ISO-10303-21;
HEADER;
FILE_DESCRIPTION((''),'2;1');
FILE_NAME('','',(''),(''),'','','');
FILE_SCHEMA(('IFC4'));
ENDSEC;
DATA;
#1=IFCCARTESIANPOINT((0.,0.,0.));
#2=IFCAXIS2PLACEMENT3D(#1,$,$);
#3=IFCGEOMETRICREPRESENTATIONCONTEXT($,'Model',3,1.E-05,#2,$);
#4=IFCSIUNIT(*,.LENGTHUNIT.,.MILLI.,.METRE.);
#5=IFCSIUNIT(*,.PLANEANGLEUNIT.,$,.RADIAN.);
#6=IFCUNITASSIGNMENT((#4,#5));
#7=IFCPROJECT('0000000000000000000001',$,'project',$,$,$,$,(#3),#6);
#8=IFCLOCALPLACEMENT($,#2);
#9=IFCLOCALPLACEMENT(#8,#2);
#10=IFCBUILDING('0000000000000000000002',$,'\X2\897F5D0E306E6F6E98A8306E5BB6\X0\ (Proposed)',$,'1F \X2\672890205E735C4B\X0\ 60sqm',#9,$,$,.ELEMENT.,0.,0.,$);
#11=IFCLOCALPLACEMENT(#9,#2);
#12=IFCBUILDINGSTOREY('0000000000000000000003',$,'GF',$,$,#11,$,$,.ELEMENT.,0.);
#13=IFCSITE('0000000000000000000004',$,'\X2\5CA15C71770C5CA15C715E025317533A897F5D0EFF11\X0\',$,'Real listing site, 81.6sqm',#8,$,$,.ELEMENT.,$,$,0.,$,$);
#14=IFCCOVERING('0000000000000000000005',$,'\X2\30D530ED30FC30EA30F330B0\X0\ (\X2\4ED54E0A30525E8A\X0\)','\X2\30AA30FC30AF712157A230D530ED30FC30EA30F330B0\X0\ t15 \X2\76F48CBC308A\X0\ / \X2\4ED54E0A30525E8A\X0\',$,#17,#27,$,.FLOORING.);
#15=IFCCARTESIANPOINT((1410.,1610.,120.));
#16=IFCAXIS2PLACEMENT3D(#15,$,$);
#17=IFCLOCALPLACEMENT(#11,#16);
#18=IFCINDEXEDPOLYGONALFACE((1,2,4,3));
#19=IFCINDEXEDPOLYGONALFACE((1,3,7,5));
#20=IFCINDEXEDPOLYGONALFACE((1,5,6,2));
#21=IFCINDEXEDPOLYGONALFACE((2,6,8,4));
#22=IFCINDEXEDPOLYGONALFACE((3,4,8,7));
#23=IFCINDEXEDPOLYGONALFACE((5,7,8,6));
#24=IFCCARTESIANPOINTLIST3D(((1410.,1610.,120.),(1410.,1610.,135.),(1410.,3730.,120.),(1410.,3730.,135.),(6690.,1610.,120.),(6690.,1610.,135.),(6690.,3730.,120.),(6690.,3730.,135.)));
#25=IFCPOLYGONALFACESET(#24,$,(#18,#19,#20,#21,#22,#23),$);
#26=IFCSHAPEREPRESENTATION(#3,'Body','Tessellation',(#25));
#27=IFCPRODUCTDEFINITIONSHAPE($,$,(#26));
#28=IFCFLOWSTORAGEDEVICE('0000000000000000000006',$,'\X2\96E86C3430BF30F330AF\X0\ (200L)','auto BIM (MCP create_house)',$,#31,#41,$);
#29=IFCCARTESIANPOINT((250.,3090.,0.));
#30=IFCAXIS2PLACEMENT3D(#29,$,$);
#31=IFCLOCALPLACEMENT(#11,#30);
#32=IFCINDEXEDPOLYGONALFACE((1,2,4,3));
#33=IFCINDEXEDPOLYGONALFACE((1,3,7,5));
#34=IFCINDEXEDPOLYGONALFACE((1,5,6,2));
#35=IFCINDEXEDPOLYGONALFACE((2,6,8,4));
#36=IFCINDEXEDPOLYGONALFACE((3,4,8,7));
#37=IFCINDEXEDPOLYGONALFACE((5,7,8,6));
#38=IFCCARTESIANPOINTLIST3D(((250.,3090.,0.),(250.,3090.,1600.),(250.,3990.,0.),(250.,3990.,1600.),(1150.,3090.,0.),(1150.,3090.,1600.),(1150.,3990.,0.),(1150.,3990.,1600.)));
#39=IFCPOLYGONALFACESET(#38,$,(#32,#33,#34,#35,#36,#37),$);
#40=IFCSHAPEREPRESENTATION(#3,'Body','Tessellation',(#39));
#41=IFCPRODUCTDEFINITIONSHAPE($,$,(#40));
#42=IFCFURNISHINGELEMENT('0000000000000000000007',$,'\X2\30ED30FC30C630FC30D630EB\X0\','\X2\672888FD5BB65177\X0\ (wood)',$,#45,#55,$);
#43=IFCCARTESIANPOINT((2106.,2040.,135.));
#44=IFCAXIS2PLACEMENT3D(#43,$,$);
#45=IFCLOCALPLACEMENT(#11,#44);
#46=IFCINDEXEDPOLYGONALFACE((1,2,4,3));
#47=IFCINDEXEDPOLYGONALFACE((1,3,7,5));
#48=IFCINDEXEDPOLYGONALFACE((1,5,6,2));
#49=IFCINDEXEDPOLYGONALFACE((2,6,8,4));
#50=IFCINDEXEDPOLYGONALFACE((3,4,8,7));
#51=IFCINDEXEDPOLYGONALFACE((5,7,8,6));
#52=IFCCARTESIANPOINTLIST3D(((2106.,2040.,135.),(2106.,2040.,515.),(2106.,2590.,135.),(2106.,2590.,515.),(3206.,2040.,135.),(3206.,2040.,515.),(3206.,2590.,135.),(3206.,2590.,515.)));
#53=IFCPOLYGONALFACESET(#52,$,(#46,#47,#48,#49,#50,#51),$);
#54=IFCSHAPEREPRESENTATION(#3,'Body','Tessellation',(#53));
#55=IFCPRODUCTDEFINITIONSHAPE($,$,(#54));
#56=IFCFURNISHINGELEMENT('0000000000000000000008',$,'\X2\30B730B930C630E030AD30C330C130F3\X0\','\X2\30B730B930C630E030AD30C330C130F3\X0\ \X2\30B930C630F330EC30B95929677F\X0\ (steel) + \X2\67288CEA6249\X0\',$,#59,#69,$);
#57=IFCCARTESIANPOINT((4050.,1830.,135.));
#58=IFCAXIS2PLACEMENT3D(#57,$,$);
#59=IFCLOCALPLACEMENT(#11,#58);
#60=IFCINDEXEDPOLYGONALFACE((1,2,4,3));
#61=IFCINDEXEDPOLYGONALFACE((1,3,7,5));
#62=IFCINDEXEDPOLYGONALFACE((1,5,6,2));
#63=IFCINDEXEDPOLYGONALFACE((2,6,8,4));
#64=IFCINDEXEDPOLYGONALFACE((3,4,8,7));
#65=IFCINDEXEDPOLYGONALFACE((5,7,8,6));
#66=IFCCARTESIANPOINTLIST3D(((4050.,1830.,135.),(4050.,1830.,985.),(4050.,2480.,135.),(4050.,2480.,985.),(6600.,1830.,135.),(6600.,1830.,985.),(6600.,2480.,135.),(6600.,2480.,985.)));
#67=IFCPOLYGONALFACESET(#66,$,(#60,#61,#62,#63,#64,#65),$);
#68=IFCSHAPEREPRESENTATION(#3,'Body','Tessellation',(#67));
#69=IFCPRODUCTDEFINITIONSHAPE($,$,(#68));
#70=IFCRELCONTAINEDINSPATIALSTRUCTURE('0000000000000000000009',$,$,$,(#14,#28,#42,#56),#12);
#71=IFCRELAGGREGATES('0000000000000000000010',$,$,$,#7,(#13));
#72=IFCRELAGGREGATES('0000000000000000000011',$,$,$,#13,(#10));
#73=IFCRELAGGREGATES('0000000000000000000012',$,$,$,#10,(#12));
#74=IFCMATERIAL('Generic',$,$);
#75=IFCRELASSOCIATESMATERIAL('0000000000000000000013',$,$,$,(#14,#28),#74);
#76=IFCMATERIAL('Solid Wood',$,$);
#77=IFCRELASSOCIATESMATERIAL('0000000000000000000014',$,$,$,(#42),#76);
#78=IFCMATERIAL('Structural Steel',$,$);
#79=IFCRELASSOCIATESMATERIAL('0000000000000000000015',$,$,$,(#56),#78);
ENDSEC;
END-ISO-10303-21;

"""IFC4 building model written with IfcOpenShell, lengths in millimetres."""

from ifc_helpers import new_model, si_unit, frame, frame_2d, origin, place, context, project, spatial, rectangle, extrude, material, element, save


model = new_model("IFC4")

# Units and contexts
model_context = context("Model", 3, precision=1e-05, world=origin())
ifc_project = project(units=[si_unit("LENGTHUNIT", "METRE", prefix="MILLI"), si_unit("PLANEANGLEUNIT", "RADIAN")], contexts=[model_context])

# Site, building, storey
site_placement = place(None, origin())
site = spatial("IfcSite", under=ifc_project, at=site_placement, Name="岡山県岡山市北区西崎１", ObjectType="Real listing site, 81.6sqm", CompositionType="ELEMENT", RefElevation=0.0)
building_placement = place(site_placement, origin())
building = spatial("IfcBuilding", under=site, at=building_placement, Name="西崎の潮風の家 (Proposed)", ObjectType="1F 木造平屋 60sqm", CompositionType="ELEMENT", ElevationOfRefHeight=0.0, ElevationOfTerrain=0.0)
storey_placement = place(building_placement, origin())
storey = spatial("IfcBuildingStorey", under=building, at=storey_placement, Name="GF", CompositionType="ELEMENT", Elevation=0.0)

# Shared definitions
ifc_material_1 = material(Name="Solid Wood")

# Covering
ifc_material_2 = material(Name="Generic")
covering_placement = place(storey_placement, frame((1410.0, 1610.0, 120.0)))
element("IfcCovering", 1, at=covering_placement, inside=storey, material=ifc_material_2, Name="フローリング (仕上げ床)", Description="オーク無垢フローリング t15 直貼り / 仕上げ床", PredefinedType="FLOORING", context=model_context, shape_type="SweptSolid", body=[
    extrude(rectangle(XDim=5280.0, YDim=2120.0, at=frame_2d((2640.0, 1060.0))), frame((1410.0, 1610.0, 120.0)), (0.0, 0.0, 1.0), 15.0),
])

# Flow storage device
flow_storage_device_placement = place(storey_placement, frame((250.0, 3090.0, 0.0)))
element("IfcFlowStorageDevice", 2, at=flow_storage_device_placement, inside=storey, material=ifc_material_2, Name="雨水タンク (200L)", Description="auto BIM (MCP create_house)", context=model_context, shape_type="SweptSolid", body=[
    extrude(rectangle(XDim=900.0, YDim=900.0, at=frame_2d((450.0, 450.0))), frame((250.0, 3090.0, 0.0)), (0.0, 0.0, 1.0), 1600.0),
])

# Furnishing elements
furnishing_1_placement = place(storey_placement, frame((2106.0, 2040.0, 135.0)))
element("IfcFurnishingElement", 3, at=furnishing_1_placement, inside=storey, material=ifc_material_1, Name="ローテーブル", Description="木製家具 (wood)", context=model_context, shape_type="SweptSolid", body=[
    extrude(rectangle(XDim=1100.0, YDim=550.0, at=frame_2d((550.0, 275.0))), frame((2106.0, 2040.0, 135.0)), (0.0, 0.0, 1.0), 380.0),
])
ifc_material_3 = material(Name="Structural Steel")
furnishing_2_placement = place(storey_placement, frame((4050.0, 1830.0, 135.0)))
element("IfcFurnishingElement", 4, at=furnishing_2_placement, inside=storey, material=ifc_material_3, Name="システムキッチン", Description="システムキッチン ステンレス天板 (steel) + 木質扉", context=model_context, shape_type="SweptSolid", body=[
    extrude(rectangle(XDim=2550.0, YDim=650.0, at=frame_2d((1275.0, 325.0))), frame((4050.0, 1830.0, 135.0)), (0.0, 0.0, 1.0), 850.0),
])

save(model, "model.ifc")
